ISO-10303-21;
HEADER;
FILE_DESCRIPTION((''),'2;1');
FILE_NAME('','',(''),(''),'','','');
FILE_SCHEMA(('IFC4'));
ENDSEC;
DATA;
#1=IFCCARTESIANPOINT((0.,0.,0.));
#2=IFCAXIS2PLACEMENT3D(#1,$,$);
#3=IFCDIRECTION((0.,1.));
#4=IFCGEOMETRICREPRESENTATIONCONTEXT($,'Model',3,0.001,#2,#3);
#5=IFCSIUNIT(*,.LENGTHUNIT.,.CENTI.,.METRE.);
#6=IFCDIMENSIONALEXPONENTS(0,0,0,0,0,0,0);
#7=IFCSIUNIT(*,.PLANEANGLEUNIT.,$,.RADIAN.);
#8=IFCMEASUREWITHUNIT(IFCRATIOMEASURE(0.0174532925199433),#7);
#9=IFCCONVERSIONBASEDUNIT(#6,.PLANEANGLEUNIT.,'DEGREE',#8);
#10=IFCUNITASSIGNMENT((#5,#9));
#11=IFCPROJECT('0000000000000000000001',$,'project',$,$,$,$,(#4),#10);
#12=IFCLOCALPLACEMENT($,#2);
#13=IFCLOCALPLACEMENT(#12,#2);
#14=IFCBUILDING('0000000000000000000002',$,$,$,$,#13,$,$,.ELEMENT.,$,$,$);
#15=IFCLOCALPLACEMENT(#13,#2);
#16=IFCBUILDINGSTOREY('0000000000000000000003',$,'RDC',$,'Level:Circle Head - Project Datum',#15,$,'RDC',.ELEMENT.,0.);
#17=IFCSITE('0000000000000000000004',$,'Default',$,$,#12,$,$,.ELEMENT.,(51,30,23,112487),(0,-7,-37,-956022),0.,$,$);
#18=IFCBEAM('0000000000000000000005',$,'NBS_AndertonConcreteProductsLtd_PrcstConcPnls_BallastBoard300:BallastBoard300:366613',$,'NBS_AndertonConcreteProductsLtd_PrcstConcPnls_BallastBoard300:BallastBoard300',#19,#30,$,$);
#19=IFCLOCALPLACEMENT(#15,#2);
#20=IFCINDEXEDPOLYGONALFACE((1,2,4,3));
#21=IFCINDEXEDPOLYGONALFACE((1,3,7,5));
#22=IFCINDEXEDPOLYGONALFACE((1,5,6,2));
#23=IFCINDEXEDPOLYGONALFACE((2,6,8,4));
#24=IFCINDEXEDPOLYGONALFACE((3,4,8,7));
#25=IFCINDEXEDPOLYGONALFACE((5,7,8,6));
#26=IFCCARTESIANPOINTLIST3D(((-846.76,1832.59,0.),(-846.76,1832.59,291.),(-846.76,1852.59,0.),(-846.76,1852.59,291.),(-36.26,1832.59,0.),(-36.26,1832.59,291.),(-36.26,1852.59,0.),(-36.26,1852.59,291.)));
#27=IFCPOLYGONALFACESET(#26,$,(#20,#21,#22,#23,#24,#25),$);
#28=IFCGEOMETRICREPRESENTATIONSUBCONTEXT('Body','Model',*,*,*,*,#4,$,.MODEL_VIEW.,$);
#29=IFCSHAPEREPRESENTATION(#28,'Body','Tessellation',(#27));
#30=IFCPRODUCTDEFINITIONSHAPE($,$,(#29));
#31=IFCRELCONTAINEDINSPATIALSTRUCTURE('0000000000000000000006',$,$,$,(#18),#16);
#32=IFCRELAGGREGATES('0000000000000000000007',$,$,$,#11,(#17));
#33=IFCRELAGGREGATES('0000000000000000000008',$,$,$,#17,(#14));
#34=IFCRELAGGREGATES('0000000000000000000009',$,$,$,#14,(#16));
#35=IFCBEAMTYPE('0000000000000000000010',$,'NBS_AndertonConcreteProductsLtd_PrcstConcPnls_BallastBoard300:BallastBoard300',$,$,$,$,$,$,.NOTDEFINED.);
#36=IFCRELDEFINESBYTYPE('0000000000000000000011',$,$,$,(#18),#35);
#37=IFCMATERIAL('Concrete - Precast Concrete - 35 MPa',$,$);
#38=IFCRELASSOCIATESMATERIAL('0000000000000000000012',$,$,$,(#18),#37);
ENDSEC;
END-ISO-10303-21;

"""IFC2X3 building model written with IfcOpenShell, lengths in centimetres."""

from ifc_helpers import new_model, entity, si_unit, converted_unit, direction, frame, frame_2d, origin, place, context, subcontext, project, spatial, rectangle, extrude, material, type_object, element, save


model = new_model("IFC2X3")

# Units and contexts
model_context = context("Model", 3, precision=0.001, world=origin(), true_north=direction((0.0, 1.0)))
body_context = subcontext(model_context, "Body", "Model", "MODEL_VIEW")
ifc_project = project(units=[si_unit("LENGTHUNIT", "METRE", prefix="CENTI"), converted_unit("PLANEANGLEUNIT", "DEGREE", entity("IfcRatioMeasure", 0.0174532925199433), si_unit("PLANEANGLEUNIT", "RADIAN"), dimensions=[0, 0, 0, 0, 0, 0, 0])], contexts=[model_context])

# Site, building, storey
site_placement = place(None, origin())
site = spatial("IfcSite", under=ifc_project, at=site_placement, Name="Default", CompositionType="ELEMENT", RefLatitude=(51, 30, 23, 112487), RefLongitude=(0, -7, -37, -956022), RefElevation=0.0)
building_placement = place(site_placement, origin())
building = spatial("IfcBuilding", under=site, at=building_placement, CompositionType="ELEMENT")
storey_placement = place(building_placement, origin())
storey = spatial("IfcBuildingStorey", under=building, at=storey_placement, Name="RDC", ObjectType="Level:Circle Head - Project Datum", LongName="RDC", CompositionType="ELEMENT", Elevation=0.0)

# Beam
ifc_material = material(Name="Concrete - Precast Concrete - 35 MPa")
beam_type = type_object("IfcBeamType", Name="NBS_AndertonConcreteProductsLtd_PrcstConcPnls_BallastBoard300:BallastBoard300", PredefinedType="NOTDEFINED")
beam_placement = place(storey_placement, origin())
element("IfcBeam", 1, at=beam_placement, inside=storey, type_object=beam_type, material=ifc_material, Name="NBS_AndertonConcreteProductsLtd_PrcstConcPnls_BallastBoard300:BallastBoard300:366613", ObjectType="NBS_AndertonConcreteProductsLtd_PrcstConcPnls_BallastBoard300:BallastBoard300", context=body_context, shape_type="SweptSolid", body=[
    extrude(rectangle(XDim=291.0, YDim=20.0, at=frame_2d((0.0, 0.0), x_axis=(0.0, 1.0))), frame((-846.76, 1842.59, 145.5), z_axis=(1.0, 0.0, 0.0), x_axis=(0.0, 1.0, 0.0)), (0.0, 0.0, 1.0), 810.5),
])

save(model, "model.ifc")
